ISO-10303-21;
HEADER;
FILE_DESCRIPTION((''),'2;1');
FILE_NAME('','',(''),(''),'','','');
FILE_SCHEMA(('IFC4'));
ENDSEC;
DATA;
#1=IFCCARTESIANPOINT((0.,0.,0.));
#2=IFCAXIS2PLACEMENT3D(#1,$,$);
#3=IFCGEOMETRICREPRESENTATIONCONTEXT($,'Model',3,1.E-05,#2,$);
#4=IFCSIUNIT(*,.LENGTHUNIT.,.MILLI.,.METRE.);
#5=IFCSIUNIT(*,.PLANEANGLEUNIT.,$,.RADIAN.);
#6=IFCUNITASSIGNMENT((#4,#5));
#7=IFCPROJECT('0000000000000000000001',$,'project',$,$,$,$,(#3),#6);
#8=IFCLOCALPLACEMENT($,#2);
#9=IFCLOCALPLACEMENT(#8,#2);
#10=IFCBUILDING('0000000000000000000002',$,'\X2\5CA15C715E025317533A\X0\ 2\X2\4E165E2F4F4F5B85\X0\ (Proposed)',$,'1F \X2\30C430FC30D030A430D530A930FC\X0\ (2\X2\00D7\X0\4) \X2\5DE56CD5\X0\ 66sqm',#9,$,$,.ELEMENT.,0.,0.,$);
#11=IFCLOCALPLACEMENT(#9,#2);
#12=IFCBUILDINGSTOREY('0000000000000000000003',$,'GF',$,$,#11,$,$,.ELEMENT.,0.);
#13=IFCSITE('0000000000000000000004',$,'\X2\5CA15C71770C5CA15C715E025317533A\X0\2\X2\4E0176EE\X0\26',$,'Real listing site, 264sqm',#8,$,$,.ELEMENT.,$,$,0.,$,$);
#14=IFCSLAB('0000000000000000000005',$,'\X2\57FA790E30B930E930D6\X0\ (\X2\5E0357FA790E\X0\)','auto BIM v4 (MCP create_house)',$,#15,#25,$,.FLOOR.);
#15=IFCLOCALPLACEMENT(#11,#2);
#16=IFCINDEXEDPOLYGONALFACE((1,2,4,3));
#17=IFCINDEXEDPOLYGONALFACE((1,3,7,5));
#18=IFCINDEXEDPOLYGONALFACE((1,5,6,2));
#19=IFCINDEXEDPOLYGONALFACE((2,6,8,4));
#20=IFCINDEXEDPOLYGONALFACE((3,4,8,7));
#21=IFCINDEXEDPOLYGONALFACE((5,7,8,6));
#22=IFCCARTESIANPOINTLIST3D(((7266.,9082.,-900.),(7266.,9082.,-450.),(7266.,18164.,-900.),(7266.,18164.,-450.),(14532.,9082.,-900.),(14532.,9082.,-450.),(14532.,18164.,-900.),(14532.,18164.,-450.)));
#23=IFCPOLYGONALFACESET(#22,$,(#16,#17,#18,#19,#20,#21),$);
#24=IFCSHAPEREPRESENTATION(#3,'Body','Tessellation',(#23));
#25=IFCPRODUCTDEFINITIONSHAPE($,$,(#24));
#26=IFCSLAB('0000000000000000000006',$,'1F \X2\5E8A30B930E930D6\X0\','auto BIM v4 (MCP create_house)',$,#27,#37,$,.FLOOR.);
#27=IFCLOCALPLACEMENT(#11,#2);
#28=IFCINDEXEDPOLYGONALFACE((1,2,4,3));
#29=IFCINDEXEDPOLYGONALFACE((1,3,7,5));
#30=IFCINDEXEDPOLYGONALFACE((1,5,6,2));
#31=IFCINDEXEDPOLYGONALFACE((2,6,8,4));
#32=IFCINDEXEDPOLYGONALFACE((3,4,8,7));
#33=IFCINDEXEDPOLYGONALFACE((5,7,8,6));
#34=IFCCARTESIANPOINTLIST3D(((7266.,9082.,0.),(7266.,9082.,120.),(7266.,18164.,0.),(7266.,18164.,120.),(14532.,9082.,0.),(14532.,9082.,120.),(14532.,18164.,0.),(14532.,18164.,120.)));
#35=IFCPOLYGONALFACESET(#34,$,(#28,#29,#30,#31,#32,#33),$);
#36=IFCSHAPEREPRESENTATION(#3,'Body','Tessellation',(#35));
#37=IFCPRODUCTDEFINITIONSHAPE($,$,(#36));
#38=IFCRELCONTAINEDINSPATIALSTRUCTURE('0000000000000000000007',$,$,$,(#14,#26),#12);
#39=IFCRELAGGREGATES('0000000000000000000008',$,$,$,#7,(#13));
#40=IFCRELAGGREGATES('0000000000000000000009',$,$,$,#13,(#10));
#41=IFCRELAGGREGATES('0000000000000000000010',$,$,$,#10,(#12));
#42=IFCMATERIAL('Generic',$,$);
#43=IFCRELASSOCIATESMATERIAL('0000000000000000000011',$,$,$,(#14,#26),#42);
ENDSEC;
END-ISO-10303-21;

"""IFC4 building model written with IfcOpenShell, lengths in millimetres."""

from ifc_helpers import new_model, si_unit, frame, frame_2d, origin, place, context, project, spatial, rectangle, extrude, material, element, save


model = new_model("IFC4")

# Units and contexts
model_context = context("Model", 3, precision=1e-05, world=origin())
ifc_project = project(units=[si_unit("LENGTHUNIT", "METRE", prefix="MILLI"), si_unit("PLANEANGLEUNIT", "RADIAN")], contexts=[model_context])

# Site, building, storey
site_placement = place(None, origin())
site = spatial("IfcSite", under=ifc_project, at=site_placement, Name="岡山県岡山市北区2丁目26", ObjectType="Real listing site, 264sqm", CompositionType="ELEMENT", RefElevation=0.0)
building_placement = place(site_placement, origin())
building = spatial("IfcBuilding", under=site, at=building_placement, Name="岡山市北区 2世帯住宅 (Proposed)", ObjectType="1F ツーバイフォー (2×4) 工法 66sqm", CompositionType="ELEMENT", ElevationOfRefHeight=0.0, ElevationOfTerrain=0.0)
storey_placement = place(building_placement, origin())
storey = spatial("IfcBuildingStorey", under=building, at=storey_placement, Name="GF", CompositionType="ELEMENT", Elevation=0.0)

# Slabs
ifc_material = material(Name="Generic")
slab_1_placement = place(storey_placement, frame((3633.0, 4541.0, -450.0)))
element("IfcSlab", 1, at=slab_1_placement, inside=storey, material=ifc_material, Name="基礎スラブ (布基礎)", Description="auto BIM v4 (MCP create_house)", PredefinedType="FLOOR", context=model_context, shape_type="SweptSolid", body=[
    extrude(rectangle(XDim=7266.0, YDim=9082.0, at=frame_2d((3633.0, 4541.0))), frame((3633.0, 4541.0, -450.0)), (0.0, 0.0, 1.0), 450.0),
])
slab_2_placement = place(storey_placement, frame((3633.0, 4541.0, 0.0)))
element("IfcSlab", 2, at=slab_2_placement, inside=storey, material=ifc_material, Name="1F 床スラブ", Description="auto BIM v4 (MCP create_house)", PredefinedType="FLOOR", context=model_context, shape_type="SweptSolid", body=[
    extrude(rectangle(XDim=7266.0, YDim=9082.0, at=frame_2d((3633.0, 4541.0))), frame((3633.0, 4541.0, 0.0)), (0.0, 0.0, 1.0), 120.0),
])

save(model, "model.ifc")
